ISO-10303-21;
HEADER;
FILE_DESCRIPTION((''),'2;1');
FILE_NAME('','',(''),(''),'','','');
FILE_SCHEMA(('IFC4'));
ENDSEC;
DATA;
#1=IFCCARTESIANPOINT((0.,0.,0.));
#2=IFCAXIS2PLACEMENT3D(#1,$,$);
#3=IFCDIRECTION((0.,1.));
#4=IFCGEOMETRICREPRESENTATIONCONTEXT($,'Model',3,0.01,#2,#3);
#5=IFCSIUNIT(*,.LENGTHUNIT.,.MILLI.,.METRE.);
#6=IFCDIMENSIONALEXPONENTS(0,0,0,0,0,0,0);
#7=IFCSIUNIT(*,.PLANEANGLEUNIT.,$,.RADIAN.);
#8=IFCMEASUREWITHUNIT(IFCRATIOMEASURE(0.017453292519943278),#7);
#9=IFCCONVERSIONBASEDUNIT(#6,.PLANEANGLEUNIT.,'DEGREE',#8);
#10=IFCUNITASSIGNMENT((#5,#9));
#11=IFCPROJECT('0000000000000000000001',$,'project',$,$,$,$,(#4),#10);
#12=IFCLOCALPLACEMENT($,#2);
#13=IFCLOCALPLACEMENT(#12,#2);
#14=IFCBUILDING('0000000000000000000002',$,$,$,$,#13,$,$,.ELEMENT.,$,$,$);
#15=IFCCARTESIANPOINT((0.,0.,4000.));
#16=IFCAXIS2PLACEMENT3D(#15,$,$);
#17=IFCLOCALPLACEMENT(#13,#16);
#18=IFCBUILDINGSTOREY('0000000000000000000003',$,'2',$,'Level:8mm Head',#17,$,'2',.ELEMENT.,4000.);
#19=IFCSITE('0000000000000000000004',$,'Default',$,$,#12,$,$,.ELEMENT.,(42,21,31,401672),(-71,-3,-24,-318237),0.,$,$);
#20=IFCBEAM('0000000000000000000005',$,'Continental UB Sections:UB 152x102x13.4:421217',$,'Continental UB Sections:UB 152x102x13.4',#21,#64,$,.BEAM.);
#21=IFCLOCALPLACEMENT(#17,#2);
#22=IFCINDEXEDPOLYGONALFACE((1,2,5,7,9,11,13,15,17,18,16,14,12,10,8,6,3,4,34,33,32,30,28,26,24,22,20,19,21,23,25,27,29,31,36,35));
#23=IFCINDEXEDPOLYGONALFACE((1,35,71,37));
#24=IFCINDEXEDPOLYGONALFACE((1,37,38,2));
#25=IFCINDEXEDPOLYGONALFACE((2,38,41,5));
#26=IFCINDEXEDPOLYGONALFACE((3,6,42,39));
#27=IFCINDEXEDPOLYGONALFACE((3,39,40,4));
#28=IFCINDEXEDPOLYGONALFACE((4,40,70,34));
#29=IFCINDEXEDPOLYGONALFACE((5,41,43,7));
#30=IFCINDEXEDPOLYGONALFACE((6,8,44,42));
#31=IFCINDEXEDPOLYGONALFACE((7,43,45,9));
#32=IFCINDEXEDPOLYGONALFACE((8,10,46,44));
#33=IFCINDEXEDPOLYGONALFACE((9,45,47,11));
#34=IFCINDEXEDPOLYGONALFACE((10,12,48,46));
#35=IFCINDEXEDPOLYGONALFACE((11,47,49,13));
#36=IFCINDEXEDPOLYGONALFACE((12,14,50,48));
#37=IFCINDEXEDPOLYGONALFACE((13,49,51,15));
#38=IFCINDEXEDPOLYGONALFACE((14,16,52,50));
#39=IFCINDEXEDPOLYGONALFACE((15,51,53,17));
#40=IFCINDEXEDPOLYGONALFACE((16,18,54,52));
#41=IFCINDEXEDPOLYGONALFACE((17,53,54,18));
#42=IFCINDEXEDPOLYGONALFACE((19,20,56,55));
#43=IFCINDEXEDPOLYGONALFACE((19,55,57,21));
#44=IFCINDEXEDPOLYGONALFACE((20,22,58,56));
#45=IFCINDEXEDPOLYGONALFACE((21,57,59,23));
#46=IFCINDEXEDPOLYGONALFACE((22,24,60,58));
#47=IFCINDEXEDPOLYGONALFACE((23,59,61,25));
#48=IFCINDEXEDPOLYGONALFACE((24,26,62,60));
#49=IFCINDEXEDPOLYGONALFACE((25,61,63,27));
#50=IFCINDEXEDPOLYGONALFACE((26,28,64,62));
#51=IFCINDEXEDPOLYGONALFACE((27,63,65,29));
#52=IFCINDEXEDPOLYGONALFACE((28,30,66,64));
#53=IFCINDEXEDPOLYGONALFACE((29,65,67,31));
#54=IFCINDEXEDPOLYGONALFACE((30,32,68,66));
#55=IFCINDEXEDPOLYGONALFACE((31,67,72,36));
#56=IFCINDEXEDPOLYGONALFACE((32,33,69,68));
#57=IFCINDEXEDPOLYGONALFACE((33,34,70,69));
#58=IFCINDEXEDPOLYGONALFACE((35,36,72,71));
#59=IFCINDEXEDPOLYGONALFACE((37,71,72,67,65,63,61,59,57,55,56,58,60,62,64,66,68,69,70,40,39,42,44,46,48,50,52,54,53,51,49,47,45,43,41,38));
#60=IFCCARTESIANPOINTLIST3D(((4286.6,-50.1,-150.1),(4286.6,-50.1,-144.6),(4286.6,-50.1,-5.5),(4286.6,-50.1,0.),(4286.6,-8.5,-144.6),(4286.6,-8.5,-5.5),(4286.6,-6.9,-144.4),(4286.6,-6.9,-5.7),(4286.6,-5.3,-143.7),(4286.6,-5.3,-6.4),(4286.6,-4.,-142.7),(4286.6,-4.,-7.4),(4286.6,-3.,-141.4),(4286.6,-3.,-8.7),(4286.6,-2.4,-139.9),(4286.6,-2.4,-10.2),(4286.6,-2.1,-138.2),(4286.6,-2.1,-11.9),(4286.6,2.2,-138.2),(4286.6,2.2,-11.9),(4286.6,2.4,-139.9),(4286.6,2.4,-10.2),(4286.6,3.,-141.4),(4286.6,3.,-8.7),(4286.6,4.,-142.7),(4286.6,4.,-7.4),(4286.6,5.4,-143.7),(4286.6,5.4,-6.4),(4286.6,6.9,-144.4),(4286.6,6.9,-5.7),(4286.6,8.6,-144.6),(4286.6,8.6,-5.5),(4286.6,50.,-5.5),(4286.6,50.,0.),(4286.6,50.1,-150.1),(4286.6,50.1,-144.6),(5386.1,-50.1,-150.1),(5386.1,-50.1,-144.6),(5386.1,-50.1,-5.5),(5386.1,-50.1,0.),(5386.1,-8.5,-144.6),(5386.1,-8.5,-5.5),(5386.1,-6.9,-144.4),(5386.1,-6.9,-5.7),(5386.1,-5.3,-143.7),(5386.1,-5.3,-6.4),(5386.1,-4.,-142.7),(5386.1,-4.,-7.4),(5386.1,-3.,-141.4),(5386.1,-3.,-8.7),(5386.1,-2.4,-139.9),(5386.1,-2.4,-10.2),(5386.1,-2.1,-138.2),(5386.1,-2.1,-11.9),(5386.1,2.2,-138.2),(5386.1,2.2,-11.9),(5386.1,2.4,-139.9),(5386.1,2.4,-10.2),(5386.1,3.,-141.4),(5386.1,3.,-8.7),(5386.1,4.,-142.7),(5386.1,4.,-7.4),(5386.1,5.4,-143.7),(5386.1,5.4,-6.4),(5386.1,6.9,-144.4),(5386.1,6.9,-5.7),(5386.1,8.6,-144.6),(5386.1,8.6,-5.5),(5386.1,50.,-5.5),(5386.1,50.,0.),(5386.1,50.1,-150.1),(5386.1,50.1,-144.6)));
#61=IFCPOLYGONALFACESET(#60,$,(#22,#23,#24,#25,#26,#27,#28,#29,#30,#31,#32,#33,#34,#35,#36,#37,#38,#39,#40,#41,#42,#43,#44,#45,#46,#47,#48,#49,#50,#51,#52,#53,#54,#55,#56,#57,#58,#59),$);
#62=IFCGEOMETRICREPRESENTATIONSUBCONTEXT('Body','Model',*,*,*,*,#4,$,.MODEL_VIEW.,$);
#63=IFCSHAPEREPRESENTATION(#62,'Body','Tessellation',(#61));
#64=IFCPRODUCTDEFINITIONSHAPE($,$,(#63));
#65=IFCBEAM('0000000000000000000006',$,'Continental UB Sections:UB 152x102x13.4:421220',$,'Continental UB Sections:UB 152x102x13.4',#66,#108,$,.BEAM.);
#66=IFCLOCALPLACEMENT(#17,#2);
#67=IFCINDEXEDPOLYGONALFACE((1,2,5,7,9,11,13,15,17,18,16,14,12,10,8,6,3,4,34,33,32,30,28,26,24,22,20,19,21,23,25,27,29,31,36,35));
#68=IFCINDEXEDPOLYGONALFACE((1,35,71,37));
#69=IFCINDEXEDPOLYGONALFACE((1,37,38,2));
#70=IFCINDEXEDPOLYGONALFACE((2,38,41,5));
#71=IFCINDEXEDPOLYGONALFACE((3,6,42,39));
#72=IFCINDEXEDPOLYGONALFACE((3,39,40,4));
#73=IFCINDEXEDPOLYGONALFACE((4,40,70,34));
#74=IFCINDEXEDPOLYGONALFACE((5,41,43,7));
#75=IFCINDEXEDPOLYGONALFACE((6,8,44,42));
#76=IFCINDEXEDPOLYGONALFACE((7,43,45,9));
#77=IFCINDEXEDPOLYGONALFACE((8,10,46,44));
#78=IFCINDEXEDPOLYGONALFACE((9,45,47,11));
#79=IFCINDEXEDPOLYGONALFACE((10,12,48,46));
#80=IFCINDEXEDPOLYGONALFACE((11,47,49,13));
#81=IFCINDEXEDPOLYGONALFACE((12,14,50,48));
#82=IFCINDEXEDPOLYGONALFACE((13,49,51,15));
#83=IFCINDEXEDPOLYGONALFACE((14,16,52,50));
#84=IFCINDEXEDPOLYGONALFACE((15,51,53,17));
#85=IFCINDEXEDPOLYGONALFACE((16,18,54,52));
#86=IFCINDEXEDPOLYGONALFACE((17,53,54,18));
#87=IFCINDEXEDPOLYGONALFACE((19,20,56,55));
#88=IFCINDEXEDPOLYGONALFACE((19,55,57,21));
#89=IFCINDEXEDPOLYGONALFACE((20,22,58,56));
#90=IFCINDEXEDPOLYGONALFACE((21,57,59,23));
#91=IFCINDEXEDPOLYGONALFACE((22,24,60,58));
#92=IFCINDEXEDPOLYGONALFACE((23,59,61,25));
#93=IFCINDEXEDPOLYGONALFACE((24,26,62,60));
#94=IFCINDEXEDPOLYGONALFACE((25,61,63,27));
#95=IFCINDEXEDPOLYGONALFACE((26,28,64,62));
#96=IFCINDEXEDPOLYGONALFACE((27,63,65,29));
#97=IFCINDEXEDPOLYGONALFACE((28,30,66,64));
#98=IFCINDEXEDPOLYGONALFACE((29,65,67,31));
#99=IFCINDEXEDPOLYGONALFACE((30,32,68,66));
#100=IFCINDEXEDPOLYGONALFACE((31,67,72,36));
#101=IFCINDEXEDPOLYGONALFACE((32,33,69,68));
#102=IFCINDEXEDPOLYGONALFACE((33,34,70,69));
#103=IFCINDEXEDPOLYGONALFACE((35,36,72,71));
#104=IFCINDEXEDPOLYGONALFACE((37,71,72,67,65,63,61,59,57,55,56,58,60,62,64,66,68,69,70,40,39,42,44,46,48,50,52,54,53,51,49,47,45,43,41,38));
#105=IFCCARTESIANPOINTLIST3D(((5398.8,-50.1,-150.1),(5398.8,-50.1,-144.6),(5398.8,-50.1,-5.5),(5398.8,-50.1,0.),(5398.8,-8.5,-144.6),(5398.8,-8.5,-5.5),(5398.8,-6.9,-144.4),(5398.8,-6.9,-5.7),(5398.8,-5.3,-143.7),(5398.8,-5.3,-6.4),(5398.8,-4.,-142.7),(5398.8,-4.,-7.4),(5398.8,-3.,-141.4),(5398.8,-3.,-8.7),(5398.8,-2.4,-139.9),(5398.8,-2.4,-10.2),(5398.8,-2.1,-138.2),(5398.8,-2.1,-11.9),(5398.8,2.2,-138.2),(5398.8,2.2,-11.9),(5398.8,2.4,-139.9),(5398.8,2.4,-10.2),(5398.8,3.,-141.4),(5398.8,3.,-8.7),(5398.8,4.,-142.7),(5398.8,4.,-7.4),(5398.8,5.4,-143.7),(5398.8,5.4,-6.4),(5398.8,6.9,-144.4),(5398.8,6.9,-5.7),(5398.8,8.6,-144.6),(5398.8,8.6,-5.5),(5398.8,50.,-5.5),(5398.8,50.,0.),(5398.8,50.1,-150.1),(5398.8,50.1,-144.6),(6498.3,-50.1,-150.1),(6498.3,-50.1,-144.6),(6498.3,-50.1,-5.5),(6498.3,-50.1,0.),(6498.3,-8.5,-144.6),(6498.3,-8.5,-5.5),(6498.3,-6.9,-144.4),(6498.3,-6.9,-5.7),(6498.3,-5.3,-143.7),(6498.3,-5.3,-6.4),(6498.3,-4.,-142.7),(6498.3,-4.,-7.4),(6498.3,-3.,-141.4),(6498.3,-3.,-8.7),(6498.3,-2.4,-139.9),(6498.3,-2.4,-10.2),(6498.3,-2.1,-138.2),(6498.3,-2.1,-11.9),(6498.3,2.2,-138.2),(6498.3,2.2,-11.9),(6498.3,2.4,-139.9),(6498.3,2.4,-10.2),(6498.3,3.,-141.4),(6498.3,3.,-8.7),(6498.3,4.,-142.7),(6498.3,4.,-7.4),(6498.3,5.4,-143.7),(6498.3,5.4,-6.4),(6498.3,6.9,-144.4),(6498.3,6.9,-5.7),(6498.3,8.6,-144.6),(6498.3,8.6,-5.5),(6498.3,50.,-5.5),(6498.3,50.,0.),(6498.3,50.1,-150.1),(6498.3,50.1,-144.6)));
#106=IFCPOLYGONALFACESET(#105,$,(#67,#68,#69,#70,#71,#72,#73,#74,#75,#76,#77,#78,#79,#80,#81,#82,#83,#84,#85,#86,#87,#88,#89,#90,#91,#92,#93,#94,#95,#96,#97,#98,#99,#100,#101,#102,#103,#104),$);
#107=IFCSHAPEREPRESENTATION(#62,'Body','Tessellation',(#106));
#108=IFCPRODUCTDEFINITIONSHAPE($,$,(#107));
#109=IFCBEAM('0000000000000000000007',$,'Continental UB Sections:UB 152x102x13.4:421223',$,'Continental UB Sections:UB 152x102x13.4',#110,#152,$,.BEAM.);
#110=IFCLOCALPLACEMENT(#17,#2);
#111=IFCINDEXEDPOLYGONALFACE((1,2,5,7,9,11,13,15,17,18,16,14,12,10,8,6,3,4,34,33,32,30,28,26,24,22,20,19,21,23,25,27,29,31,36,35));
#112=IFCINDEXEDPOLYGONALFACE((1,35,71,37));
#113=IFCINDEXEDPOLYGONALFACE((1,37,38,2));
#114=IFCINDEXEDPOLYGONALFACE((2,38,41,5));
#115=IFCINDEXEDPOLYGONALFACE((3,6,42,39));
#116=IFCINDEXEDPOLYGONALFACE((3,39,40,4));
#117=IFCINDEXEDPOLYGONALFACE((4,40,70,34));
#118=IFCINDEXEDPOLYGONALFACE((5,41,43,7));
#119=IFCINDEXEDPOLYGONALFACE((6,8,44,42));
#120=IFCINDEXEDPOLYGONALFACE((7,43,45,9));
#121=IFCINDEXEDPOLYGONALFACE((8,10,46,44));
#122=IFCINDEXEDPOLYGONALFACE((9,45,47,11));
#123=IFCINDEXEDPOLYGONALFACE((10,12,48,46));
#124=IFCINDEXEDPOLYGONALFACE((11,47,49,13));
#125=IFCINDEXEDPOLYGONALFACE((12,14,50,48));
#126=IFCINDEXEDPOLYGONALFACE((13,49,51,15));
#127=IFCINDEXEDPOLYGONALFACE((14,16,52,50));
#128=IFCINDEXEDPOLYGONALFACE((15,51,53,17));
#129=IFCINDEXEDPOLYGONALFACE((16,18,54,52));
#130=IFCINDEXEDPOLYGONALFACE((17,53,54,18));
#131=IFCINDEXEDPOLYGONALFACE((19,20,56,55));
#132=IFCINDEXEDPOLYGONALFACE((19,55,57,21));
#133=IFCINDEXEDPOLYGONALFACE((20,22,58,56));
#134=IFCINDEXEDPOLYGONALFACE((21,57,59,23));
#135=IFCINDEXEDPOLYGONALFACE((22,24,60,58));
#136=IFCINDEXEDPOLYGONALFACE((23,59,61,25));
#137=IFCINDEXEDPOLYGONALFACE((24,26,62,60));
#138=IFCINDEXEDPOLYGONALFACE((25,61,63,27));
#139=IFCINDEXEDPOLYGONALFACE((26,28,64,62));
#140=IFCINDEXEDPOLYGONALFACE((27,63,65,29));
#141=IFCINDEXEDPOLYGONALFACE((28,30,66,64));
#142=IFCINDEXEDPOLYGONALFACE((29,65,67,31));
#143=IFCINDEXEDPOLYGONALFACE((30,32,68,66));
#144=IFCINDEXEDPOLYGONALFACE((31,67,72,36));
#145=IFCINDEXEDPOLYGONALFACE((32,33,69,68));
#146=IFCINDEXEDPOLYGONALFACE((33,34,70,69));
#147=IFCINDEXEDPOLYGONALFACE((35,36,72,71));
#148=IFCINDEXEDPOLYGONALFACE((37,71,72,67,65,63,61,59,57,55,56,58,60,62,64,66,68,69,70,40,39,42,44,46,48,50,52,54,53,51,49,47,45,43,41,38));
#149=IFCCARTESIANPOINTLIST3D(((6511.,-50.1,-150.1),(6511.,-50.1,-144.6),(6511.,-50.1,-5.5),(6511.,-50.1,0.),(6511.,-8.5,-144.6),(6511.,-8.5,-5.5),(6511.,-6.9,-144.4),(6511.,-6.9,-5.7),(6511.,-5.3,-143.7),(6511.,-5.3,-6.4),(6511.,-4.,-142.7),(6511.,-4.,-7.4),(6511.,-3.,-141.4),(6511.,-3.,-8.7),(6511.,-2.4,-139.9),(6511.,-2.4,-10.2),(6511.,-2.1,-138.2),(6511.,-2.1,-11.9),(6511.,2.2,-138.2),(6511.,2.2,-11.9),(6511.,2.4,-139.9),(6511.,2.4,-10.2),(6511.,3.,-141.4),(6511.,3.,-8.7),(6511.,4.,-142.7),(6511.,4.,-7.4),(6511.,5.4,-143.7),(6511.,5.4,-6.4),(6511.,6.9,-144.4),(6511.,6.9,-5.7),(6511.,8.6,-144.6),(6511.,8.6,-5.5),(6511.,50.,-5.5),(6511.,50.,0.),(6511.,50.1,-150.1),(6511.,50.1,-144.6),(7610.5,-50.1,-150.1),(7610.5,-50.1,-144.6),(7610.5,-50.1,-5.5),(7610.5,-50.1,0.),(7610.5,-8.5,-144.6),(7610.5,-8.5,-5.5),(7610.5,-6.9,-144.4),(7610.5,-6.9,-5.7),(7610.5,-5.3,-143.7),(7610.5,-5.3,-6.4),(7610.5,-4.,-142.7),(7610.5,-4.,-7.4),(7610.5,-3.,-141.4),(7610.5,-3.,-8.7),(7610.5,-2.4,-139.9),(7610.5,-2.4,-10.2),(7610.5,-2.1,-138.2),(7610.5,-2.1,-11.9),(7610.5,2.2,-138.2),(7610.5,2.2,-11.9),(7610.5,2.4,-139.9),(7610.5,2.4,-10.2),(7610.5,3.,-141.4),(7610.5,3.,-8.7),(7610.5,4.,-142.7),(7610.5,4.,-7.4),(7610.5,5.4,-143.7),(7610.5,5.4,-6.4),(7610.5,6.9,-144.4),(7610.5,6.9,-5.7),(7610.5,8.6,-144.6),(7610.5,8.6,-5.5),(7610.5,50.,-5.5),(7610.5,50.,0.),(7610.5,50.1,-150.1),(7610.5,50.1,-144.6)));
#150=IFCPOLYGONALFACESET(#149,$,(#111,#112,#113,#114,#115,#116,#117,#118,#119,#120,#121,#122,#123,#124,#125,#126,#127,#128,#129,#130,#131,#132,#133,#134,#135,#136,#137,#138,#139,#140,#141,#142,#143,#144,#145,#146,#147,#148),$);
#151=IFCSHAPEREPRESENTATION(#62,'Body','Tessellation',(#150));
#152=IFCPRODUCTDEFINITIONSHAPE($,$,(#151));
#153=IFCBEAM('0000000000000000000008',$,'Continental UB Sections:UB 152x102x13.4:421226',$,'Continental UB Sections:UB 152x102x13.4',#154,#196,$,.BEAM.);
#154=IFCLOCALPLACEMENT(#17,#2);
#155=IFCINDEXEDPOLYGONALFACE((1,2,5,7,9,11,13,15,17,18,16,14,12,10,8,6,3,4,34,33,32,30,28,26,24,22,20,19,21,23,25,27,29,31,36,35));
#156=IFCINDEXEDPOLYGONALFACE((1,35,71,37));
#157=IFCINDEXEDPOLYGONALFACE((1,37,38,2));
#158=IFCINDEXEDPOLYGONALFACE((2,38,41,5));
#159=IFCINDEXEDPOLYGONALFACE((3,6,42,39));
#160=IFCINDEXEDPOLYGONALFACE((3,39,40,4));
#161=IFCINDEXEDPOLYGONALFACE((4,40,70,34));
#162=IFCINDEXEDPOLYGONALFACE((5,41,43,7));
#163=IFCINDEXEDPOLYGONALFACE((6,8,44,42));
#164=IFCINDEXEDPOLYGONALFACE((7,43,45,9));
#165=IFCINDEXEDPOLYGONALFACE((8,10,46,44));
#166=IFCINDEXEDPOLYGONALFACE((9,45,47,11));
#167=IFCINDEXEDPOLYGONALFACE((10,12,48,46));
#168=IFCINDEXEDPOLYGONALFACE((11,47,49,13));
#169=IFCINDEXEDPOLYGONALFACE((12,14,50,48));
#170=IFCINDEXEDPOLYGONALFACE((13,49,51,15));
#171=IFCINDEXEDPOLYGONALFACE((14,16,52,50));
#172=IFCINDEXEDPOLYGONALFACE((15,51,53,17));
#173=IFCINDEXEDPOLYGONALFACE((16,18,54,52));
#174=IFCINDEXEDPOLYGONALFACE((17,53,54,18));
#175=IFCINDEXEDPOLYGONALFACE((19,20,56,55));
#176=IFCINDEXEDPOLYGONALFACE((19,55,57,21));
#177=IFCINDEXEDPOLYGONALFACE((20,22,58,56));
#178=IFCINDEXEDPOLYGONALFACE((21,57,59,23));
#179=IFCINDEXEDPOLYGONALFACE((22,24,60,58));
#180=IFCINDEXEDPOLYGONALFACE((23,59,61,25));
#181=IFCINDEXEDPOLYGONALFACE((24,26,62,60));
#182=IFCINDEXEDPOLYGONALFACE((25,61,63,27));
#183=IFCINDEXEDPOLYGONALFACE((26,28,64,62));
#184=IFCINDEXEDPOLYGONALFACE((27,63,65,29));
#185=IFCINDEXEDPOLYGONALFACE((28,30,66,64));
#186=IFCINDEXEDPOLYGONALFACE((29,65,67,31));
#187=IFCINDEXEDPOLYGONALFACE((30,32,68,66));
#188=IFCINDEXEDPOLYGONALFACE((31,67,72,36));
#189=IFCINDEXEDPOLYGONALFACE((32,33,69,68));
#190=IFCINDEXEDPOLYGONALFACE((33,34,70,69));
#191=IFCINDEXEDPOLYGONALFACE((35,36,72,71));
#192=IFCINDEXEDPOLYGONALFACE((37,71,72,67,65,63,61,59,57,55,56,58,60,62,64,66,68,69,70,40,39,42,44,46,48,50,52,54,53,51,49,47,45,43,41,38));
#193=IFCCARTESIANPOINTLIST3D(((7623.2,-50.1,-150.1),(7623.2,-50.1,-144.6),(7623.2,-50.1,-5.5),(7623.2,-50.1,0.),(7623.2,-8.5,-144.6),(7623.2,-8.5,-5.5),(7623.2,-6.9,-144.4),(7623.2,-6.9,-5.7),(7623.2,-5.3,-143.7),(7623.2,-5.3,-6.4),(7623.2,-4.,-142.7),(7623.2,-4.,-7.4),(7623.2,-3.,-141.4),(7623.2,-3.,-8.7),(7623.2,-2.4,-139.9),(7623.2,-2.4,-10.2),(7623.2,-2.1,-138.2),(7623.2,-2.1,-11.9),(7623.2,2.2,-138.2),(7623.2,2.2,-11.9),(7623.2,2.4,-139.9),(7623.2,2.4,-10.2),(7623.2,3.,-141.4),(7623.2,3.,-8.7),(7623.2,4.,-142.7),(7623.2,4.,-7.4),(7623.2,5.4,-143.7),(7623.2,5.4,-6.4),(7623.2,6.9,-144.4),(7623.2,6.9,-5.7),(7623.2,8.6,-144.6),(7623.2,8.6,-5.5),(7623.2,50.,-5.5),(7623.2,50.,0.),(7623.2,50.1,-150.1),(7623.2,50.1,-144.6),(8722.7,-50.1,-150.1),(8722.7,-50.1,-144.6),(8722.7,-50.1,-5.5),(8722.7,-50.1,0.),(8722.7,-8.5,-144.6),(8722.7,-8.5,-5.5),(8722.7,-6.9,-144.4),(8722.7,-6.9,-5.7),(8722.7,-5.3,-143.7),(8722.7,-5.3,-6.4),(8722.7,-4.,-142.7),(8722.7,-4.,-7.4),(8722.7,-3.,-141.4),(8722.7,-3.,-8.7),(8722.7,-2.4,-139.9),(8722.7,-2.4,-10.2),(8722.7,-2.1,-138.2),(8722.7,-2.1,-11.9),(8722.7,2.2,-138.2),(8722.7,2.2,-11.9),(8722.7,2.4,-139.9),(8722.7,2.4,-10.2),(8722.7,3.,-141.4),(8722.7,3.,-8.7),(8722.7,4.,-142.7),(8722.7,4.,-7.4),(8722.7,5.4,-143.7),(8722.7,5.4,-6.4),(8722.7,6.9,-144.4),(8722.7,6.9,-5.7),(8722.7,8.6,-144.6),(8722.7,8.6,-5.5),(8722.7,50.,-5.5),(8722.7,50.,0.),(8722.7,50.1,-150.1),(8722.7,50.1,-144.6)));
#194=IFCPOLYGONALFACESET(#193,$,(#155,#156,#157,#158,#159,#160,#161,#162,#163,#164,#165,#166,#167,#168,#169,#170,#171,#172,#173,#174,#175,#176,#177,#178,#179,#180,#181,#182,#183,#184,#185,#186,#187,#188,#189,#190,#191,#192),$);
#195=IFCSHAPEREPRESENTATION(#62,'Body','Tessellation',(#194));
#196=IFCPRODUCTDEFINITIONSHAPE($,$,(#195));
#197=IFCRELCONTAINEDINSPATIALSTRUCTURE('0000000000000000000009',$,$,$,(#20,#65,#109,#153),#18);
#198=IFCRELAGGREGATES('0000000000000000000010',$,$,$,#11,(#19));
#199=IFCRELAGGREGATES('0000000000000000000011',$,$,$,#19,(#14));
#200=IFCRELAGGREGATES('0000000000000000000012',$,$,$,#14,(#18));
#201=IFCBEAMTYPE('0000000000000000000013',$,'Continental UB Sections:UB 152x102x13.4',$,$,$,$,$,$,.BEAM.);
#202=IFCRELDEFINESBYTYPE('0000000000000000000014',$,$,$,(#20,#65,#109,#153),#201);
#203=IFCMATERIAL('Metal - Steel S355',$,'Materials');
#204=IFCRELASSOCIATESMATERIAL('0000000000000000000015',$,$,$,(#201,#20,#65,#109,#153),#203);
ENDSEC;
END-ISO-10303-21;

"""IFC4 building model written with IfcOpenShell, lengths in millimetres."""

from ifc_helpers import new_model, entity, si_unit, converted_unit, direction, frame, origin, place, context, subcontext, project, spatial, line, arc, indexed_curve, outline, extrude, source, transform, mapped, material, type_object, type_shapes, element, save


model = new_model("IFC4")

# Units and contexts
model_context = context("Model", 3, precision=0.01, world=origin(), true_north=direction((0.0, 1.0)))
body_context = subcontext(model_context, "Body", "Model", "MODEL_VIEW")
ifc_project = project(units=[si_unit("LENGTHUNIT", "METRE", prefix="MILLI"), converted_unit("PLANEANGLEUNIT", "DEGREE", entity("IfcRatioMeasure", 0.017453292519943278), si_unit("PLANEANGLEUNIT", "RADIAN"), dimensions=[0, 0, 0, 0, 0, 0, 0])], contexts=[model_context])

# Site, building, storey
site_placement = place(None, origin())
site = spatial("IfcSite", under=ifc_project, at=site_placement, Name="Default", CompositionType="ELEMENT", RefLatitude=(42, 21, 31, 401672), RefLongitude=(-71, -3, -24, -318237), RefElevation=0.0)
building_placement = place(site_placement, origin())
building = spatial("IfcBuilding", under=site, at=building_placement, CompositionType="ELEMENT")
storey_placement = place(building_placement, frame((0.0, 0.0, 4000.0)))
storey = spatial("IfcBuildingStorey", under=building, at=storey_placement, Name="2", ObjectType="Level:8mm Head", LongName="2", CompositionType="ELEMENT", Elevation=4000.0)

# Beams
ifc_material_1 = material(Name="Metal - Steel S355", Category="Materials")
beam_type_1 = type_object("IfcBeamType", Name="Continental UB Sections:UB 152x102x13.4", PredefinedType="BEAM", material=ifc_material_1)
shared_shape_1 = source(origin(), body_context, "Body", "SweptSolid", [
    extrude(outline(indexed_curve([(-75.0, -50.1), (-69.6, -50.1), (-69.6, -8.5), (-67.7, -4.0), (-63.2, -2.1), (63.1, -2.1), (67.7, -4.0), (69.5, -8.5), (69.5, -50.1), (75.1, -50.1), (75.1, 50.1), (69.5, 50.1), (69.5, 8.6), (67.7, 4.0), (63.1, 2.2), (-63.2, 2.2), (-67.7, 4.0), (-69.6, 8.6), (-69.6, 50.0), (-75.0, 50.0)], segments=[line(1, 2, 3), arc(3, 4, 5), line(5, 6), arc(6, 7, 8), line(8, 9, 10, 11, 12, 13), arc(13, 14, 15), line(15, 16), arc(16, 17, 18), line(18, 19, 20, 1)], self_intersect=False)), frame((-606.2, 0.0, 0.0), z_axis=(1.0, 0.0, 0.0), x_axis=(0.0, 0.0, -1.0)), (0.0, 0.0, 1.0), 1099.5),
])
type_shapes(beam_type_1, [shared_shape_1])
for number, where, name in (
    (1, (4892.8, 0.0, -75.1), "Continental UB Sections:UB 152x102x13.4:421217"),
    (2, (6005.0, 0.0, -75.1), "Continental UB Sections:UB 152x102x13.4:421220"),
    (3, (7117.2, 0.0, -75.1), "Continental UB Sections:UB 152x102x13.4:421223"),
    (4, (8229.4, 0.0, -75.1), "Continental UB Sections:UB 152x102x13.4:421226"),
):
    element("IfcBeam", number, at=place(storey_placement, frame(where)), inside=storey, type_object=beam_type_1, material=ifc_material_1, Name=name, ObjectType="Continental UB Sections:UB 152x102x13.4", PredefinedType="BEAM", context=body_context, shape_type="MappedRepresentation", body=[
        mapped(shared_shape_1, transform((0.0, 0.0, 0.0), scale=1.0)),
    ])

save(model, "model.ifc")
